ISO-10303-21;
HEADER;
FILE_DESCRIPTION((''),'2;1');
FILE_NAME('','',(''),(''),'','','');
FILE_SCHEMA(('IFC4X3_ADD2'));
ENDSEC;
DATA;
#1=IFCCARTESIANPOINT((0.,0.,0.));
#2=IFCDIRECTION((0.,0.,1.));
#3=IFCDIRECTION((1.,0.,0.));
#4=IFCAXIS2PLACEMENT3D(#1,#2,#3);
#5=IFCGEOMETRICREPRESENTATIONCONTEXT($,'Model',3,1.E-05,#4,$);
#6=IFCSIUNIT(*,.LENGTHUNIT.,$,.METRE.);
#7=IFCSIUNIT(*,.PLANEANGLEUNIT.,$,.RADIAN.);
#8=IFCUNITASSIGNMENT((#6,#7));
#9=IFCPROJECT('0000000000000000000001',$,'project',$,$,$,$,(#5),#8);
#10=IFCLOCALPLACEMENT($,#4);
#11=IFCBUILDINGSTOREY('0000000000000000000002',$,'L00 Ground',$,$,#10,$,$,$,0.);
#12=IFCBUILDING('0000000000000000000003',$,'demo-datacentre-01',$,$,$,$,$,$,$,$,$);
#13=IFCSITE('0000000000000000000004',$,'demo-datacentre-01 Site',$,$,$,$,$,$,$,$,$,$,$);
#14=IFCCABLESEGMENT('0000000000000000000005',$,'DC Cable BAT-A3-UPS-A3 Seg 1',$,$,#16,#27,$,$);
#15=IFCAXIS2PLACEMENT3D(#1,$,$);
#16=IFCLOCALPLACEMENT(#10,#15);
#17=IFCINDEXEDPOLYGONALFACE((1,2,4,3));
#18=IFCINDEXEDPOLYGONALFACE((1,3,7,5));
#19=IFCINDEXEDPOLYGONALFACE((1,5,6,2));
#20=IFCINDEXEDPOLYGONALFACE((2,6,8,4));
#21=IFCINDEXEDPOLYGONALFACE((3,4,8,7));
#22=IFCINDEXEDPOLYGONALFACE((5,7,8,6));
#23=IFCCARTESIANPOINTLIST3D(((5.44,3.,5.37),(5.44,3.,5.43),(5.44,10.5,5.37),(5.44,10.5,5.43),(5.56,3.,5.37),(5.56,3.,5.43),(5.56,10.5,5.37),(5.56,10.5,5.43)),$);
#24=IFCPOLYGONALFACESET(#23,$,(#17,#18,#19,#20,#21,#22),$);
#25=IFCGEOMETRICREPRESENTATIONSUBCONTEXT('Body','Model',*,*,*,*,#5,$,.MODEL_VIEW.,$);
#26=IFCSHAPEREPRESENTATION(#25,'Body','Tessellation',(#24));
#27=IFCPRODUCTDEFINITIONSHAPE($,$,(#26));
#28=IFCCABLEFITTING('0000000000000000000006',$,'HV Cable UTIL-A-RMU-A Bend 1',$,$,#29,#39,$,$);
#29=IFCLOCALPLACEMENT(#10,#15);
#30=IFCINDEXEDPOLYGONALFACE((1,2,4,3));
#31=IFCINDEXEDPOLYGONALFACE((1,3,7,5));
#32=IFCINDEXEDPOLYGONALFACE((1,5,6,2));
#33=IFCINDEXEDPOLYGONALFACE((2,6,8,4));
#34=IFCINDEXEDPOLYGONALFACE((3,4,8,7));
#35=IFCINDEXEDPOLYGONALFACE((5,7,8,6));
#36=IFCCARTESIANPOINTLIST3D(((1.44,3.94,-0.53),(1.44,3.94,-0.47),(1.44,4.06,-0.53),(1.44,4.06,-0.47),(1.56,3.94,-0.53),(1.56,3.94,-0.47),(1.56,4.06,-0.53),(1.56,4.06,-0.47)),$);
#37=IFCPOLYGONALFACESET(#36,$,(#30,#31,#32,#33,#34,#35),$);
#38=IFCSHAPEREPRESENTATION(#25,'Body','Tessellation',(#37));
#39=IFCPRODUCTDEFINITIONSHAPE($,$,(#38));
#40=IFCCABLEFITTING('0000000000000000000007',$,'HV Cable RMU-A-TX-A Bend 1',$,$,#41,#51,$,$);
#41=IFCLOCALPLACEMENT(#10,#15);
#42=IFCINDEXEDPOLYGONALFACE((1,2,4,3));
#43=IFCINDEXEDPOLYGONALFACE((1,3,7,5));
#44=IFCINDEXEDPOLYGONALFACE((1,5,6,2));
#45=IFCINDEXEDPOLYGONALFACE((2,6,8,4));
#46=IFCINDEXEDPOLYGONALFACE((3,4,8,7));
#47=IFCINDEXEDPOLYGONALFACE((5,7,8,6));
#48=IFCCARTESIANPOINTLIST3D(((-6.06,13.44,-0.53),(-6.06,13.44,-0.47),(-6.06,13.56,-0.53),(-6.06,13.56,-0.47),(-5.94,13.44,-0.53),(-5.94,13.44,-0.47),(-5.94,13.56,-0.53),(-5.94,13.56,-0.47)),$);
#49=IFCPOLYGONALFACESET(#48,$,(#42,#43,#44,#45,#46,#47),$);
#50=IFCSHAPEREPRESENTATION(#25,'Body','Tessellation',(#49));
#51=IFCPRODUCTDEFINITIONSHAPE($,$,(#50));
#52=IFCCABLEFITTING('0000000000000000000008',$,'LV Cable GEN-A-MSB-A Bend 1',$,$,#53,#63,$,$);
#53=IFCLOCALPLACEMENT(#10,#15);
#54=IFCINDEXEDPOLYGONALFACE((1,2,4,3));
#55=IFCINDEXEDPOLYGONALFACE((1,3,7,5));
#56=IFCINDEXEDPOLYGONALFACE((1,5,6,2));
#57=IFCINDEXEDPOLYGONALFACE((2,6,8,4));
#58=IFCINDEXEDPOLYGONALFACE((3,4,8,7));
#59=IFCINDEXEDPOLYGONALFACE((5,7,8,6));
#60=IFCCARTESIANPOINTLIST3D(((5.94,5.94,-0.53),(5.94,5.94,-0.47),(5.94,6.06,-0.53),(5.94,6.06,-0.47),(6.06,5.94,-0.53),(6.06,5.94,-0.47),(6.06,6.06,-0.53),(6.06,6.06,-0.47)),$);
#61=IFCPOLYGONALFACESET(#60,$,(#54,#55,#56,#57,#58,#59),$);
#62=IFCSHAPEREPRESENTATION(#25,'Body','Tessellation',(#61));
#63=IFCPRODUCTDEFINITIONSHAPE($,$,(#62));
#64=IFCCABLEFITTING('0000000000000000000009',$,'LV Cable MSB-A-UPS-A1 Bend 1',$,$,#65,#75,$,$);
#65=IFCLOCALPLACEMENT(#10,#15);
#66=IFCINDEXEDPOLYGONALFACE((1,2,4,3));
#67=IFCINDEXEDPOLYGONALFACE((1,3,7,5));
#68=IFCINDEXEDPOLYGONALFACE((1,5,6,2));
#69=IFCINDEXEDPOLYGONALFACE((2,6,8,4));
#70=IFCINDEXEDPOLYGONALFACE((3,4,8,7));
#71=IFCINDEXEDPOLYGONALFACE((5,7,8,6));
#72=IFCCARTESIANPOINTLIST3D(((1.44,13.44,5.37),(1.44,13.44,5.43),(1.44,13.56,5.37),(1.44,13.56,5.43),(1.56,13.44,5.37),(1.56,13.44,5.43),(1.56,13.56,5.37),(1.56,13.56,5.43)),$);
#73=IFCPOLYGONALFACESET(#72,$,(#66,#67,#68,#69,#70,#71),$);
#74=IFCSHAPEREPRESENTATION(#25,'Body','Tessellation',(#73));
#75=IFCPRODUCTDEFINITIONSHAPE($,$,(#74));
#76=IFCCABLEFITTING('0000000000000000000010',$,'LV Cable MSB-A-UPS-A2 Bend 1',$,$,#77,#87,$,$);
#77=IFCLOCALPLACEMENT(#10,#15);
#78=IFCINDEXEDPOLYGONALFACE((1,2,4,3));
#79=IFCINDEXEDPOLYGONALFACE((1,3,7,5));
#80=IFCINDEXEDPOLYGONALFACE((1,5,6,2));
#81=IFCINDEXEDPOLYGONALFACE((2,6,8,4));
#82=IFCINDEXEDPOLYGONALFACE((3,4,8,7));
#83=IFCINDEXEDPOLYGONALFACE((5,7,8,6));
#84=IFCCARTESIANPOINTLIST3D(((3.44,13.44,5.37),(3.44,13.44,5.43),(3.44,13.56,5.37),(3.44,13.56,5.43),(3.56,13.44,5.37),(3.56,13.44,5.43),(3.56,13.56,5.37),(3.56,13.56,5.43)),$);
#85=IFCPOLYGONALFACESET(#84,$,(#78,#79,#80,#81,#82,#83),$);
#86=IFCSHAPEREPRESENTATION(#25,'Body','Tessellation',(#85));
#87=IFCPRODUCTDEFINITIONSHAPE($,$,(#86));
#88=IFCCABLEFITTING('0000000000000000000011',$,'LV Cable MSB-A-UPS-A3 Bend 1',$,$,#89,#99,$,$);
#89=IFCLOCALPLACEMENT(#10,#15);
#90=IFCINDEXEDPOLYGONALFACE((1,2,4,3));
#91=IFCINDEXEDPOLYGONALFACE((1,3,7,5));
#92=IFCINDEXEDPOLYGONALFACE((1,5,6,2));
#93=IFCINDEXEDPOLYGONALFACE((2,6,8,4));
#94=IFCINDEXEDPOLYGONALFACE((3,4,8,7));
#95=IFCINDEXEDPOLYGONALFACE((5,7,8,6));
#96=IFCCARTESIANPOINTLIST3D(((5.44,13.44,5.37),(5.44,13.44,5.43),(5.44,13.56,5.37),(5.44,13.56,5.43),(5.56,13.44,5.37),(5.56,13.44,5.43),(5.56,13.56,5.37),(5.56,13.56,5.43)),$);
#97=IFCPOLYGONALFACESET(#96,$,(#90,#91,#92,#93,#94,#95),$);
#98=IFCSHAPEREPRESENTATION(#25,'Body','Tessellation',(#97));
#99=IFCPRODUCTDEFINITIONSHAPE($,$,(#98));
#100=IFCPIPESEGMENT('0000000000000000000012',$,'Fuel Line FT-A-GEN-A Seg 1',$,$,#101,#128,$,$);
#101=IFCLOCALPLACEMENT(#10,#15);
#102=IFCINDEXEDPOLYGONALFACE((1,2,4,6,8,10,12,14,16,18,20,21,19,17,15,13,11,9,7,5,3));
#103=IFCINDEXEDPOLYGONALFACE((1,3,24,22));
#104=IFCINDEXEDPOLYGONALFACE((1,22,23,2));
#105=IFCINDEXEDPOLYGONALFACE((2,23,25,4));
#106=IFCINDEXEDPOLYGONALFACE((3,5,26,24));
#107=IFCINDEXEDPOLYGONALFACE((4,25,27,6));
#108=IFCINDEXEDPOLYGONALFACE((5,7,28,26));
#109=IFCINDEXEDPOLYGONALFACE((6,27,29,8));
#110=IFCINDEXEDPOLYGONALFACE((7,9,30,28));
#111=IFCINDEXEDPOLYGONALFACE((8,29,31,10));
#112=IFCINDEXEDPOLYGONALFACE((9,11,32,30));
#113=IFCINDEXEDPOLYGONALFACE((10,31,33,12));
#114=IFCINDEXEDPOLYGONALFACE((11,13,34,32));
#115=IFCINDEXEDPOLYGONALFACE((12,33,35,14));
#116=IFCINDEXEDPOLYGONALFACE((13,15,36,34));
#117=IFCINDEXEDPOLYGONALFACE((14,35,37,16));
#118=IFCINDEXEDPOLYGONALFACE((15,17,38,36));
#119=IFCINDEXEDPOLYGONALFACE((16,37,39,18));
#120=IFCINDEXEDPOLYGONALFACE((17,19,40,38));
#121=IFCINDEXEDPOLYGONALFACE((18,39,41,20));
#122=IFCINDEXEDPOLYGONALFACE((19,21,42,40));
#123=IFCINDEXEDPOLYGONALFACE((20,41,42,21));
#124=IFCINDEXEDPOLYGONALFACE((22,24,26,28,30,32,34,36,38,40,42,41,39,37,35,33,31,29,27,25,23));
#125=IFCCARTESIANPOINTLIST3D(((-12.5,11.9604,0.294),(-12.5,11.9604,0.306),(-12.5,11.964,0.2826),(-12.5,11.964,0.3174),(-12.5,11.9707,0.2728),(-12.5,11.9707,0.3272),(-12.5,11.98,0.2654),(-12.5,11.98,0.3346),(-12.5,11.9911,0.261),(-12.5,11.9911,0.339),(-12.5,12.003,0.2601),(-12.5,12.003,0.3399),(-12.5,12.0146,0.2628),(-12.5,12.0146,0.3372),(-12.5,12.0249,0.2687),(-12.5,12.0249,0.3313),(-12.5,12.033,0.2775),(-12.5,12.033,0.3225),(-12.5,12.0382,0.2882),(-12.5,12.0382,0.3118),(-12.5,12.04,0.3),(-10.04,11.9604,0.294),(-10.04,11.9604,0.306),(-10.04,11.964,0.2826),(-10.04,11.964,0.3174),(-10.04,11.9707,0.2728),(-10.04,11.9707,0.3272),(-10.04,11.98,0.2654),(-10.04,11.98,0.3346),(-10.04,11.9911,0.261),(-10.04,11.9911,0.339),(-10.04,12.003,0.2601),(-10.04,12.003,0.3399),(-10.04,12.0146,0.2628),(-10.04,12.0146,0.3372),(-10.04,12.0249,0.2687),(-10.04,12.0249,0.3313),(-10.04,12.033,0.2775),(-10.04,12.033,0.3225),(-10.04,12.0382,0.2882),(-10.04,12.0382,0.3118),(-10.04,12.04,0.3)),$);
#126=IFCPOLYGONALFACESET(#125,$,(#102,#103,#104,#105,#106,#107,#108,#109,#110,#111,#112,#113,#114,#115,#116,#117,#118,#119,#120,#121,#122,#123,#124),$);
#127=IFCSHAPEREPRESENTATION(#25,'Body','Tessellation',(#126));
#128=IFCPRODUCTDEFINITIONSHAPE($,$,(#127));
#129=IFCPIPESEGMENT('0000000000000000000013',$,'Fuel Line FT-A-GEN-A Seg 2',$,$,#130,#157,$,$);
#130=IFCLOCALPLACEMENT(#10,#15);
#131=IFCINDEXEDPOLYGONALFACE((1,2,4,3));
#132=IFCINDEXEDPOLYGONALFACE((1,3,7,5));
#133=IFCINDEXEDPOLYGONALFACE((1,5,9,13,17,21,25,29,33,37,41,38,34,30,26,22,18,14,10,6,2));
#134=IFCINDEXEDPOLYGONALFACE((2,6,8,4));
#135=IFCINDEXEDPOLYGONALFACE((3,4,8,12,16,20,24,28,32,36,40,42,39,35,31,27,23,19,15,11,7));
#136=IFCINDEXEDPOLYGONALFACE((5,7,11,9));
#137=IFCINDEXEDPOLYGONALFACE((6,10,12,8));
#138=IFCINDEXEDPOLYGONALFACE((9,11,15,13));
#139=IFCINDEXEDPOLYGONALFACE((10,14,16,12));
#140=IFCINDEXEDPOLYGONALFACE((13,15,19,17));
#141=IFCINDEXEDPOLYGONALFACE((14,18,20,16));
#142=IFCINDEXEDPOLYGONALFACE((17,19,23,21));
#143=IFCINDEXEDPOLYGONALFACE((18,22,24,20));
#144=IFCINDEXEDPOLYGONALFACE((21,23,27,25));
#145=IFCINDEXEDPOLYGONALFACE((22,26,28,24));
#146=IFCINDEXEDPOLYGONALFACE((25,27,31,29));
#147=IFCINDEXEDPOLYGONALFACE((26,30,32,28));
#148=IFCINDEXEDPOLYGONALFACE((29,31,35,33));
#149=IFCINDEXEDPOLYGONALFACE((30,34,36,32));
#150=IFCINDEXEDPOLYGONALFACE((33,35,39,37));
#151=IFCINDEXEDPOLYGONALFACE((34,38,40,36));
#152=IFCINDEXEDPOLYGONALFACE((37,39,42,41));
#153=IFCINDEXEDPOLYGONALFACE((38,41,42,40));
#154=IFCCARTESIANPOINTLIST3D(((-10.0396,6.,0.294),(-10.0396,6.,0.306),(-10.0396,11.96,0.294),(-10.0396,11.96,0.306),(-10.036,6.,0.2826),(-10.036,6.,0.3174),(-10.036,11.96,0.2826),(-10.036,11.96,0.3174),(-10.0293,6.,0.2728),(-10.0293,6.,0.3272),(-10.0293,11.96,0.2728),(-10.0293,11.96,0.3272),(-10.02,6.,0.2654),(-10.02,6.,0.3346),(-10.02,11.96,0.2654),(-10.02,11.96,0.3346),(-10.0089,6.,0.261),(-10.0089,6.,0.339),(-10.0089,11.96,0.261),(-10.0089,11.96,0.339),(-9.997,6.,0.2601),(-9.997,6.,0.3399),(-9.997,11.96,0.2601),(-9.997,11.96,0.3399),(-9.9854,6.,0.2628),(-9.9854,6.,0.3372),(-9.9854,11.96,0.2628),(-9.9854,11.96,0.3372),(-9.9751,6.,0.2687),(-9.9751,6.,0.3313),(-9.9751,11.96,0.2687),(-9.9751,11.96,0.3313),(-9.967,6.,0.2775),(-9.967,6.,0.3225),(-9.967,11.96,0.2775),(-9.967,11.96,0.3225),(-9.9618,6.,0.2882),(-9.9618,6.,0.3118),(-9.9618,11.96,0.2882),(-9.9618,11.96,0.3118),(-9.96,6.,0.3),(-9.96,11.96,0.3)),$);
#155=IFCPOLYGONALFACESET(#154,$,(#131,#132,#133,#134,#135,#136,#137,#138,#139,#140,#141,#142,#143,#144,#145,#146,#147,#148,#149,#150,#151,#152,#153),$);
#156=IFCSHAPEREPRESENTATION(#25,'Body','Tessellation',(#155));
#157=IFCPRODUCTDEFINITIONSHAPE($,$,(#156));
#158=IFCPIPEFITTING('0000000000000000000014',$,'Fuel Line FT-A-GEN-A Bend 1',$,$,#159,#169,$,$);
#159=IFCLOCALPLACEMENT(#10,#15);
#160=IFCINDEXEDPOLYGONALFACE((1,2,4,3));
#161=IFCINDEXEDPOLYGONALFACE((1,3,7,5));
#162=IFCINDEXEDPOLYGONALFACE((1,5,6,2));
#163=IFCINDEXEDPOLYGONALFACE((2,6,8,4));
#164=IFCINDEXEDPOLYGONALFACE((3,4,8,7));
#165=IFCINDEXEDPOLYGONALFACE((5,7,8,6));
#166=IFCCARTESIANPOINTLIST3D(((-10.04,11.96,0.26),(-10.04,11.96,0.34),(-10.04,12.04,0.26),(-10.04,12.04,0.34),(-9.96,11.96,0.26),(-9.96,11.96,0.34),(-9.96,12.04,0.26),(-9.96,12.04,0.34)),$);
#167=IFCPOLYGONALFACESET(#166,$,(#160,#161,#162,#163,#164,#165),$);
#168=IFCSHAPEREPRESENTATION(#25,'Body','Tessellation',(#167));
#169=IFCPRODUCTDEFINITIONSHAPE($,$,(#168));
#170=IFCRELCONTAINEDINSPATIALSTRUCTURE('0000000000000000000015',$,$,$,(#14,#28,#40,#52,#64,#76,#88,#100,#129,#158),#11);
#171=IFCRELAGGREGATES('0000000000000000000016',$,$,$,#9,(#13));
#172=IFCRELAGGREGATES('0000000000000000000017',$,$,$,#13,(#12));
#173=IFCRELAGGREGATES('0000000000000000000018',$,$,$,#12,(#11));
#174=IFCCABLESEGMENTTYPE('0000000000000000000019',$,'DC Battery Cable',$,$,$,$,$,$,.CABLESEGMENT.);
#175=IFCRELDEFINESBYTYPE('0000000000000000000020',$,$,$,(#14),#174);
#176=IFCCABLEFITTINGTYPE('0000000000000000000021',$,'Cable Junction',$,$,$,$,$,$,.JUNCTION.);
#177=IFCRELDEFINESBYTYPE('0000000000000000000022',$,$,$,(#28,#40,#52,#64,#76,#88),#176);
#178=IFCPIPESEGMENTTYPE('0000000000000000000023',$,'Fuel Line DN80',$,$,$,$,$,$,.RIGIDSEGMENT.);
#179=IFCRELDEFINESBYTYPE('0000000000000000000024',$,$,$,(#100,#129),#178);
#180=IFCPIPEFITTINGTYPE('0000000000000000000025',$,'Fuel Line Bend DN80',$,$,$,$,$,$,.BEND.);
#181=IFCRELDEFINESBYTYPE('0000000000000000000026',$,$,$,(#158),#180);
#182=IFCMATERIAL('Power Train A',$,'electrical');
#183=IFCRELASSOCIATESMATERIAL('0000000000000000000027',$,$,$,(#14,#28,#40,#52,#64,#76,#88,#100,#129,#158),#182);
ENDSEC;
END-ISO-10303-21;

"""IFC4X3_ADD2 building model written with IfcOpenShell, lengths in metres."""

from ifc_helpers import new_model, si_unit, frame, origin_with_axes, place, context, subcontext, project, spatial, rectangle, circle, extrude, material, type_object, element, save


model = new_model("IFC4X3_ADD2")

# Units and contexts
model_context = context("Model", 3, precision=1e-05, world=origin_with_axes())
body_context = subcontext(model_context, "Body", "Model", "MODEL_VIEW")
ifc_project = project(units=[si_unit("LENGTHUNIT", "METRE"), si_unit("PLANEANGLEUNIT", "RADIAN")], contexts=[model_context])

# Site, building, storey
site = spatial("IfcSite", under=ifc_project, Name="demo-datacentre-01 Site")
building = spatial("IfcBuilding", under=site, Name="demo-datacentre-01")
storey_placement = place(None, origin_with_axes())
storey = spatial("IfcBuildingStorey", under=building, at=storey_placement, Name="L00 Ground", Elevation=0.0)

# Shared definitions
ifc_material = material(Name="Power Train A", Category="electrical")

# Cable segment
cable_segment_type_1 = type_object("IfcCableSegmentType", Name="DC Battery Cable", PredefinedType="CABLESEGMENT")
for number, where, z_axis, x_axis, name in (
    (1, (5.5, 3.0, 5.4), (0.0, 1.0, 0.0), (-1.0, 0.0, 0.0), "DC Cable BAT-A3-UPS-A3 Seg 1"),
):
    element("IfcCableSegment", number, at=place(storey_placement, frame(where, z_axis=z_axis, x_axis=x_axis)), inside=storey, type_object=cable_segment_type_1, material=ifc_material, Name=name, context=body_context, shape_type="SweptSolid", body=[
        extrude(rectangle(XDim=0.12, YDim=0.06), origin_with_axes(), (0.0, 0.0, 1.0), 7.5),
    ])

# Cable fittings
cable_fitting_type = type_object("IfcCableFittingType", Name="Cable Junction", PredefinedType="JUNCTION")
for number, where, z_axis, x_axis, name in (
    (2, (1.5, 4.0, -0.53), (0.0, 0.0, 1.0), (1.0, 0.0, 0.0), "HV Cable UTIL-A-RMU-A Bend 1"),
    (3, (-6.0, 13.5, -0.53), (0.0, 0.0, 1.0), (1.0, 0.0, 0.0), "HV Cable RMU-A-TX-A Bend 1"),
    (4, (6.0, 6.0, -0.53), (0.0, 0.0, 1.0), (1.0, 0.0, 0.0), "LV Cable GEN-A-MSB-A Bend 1"),
    (5, (1.5, 13.5, 5.37), (0.0, 0.0, 1.0), (1.0, 0.0, 0.0), "LV Cable MSB-A-UPS-A1 Bend 1"),
    (6, (3.5, 13.5, 5.37), (0.0, 0.0, 1.0), (1.0, 0.0, 0.0), "LV Cable MSB-A-UPS-A2 Bend 1"),
    (7, (5.5, 13.5, 5.37), (0.0, 0.0, 1.0), (1.0, 0.0, 0.0), "LV Cable MSB-A-UPS-A3 Bend 1"),
):
    element("IfcCableFitting", number, at=place(storey_placement, frame(where, z_axis=z_axis, x_axis=x_axis)), inside=storey, type_object=cable_fitting_type, material=ifc_material, Name=name, context=body_context, shape_type="SweptSolid", body=[
        extrude(rectangle(XDim=0.12, YDim=0.12), origin_with_axes(), (0.0, 0.0, 1.0), 0.06),
    ])

# Pipe segments
pipe_segment_type = type_object("IfcPipeSegmentType", Name="Fuel Line DN80", PredefinedType="RIGIDSEGMENT")
pipe_segment_1_placement = place(storey_placement, frame((-12.5, 12.0, 0.3), z_axis=(1.0, 0.0, 0.0), x_axis=(0.0, 1.0, 0.0)))
element("IfcPipeSegment", 8, at=pipe_segment_1_placement, inside=storey, type_object=pipe_segment_type, material=ifc_material, Name="Fuel Line FT-A-GEN-A Seg 1", context=body_context, shape_type="SweptSolid", body=[
    extrude(circle(Radius=0.04), origin_with_axes(), (0.0, 0.0, 1.0), 2.46),
])
pipe_segment_2_placement = place(storey_placement, frame((-10.0, 11.96, 0.3), z_axis=(0.0, -1.0, 0.0), x_axis=(1.0, 0.0, 0.0)))
element("IfcPipeSegment", 9, at=pipe_segment_2_placement, inside=storey, type_object=pipe_segment_type, material=ifc_material, Name="Fuel Line FT-A-GEN-A Seg 2", context=body_context, shape_type="SweptSolid", body=[
    extrude(circle(Radius=0.04), origin_with_axes(), (0.0, 0.0, 1.0), 5.96),
])

# Pipe fitting
pipe_fitting_type = type_object("IfcPipeFittingType", Name="Fuel Line Bend DN80", PredefinedType="BEND")
pipe_fitting_placement = place(storey_placement, frame((-10.0, 12.0, 0.26), z_axis=(0.0, 0.0, 1.0), x_axis=(1.0, 0.0, 0.0)))
element("IfcPipeFitting", 10, at=pipe_fitting_placement, inside=storey, type_object=pipe_fitting_type, material=ifc_material, Name="Fuel Line FT-A-GEN-A Bend 1", context=body_context, shape_type="SweptSolid", body=[
    extrude(rectangle(XDim=0.08, YDim=0.08), origin_with_axes(), (0.0, 0.0, 1.0), 0.08),
])

save(model, "model.ifc")
